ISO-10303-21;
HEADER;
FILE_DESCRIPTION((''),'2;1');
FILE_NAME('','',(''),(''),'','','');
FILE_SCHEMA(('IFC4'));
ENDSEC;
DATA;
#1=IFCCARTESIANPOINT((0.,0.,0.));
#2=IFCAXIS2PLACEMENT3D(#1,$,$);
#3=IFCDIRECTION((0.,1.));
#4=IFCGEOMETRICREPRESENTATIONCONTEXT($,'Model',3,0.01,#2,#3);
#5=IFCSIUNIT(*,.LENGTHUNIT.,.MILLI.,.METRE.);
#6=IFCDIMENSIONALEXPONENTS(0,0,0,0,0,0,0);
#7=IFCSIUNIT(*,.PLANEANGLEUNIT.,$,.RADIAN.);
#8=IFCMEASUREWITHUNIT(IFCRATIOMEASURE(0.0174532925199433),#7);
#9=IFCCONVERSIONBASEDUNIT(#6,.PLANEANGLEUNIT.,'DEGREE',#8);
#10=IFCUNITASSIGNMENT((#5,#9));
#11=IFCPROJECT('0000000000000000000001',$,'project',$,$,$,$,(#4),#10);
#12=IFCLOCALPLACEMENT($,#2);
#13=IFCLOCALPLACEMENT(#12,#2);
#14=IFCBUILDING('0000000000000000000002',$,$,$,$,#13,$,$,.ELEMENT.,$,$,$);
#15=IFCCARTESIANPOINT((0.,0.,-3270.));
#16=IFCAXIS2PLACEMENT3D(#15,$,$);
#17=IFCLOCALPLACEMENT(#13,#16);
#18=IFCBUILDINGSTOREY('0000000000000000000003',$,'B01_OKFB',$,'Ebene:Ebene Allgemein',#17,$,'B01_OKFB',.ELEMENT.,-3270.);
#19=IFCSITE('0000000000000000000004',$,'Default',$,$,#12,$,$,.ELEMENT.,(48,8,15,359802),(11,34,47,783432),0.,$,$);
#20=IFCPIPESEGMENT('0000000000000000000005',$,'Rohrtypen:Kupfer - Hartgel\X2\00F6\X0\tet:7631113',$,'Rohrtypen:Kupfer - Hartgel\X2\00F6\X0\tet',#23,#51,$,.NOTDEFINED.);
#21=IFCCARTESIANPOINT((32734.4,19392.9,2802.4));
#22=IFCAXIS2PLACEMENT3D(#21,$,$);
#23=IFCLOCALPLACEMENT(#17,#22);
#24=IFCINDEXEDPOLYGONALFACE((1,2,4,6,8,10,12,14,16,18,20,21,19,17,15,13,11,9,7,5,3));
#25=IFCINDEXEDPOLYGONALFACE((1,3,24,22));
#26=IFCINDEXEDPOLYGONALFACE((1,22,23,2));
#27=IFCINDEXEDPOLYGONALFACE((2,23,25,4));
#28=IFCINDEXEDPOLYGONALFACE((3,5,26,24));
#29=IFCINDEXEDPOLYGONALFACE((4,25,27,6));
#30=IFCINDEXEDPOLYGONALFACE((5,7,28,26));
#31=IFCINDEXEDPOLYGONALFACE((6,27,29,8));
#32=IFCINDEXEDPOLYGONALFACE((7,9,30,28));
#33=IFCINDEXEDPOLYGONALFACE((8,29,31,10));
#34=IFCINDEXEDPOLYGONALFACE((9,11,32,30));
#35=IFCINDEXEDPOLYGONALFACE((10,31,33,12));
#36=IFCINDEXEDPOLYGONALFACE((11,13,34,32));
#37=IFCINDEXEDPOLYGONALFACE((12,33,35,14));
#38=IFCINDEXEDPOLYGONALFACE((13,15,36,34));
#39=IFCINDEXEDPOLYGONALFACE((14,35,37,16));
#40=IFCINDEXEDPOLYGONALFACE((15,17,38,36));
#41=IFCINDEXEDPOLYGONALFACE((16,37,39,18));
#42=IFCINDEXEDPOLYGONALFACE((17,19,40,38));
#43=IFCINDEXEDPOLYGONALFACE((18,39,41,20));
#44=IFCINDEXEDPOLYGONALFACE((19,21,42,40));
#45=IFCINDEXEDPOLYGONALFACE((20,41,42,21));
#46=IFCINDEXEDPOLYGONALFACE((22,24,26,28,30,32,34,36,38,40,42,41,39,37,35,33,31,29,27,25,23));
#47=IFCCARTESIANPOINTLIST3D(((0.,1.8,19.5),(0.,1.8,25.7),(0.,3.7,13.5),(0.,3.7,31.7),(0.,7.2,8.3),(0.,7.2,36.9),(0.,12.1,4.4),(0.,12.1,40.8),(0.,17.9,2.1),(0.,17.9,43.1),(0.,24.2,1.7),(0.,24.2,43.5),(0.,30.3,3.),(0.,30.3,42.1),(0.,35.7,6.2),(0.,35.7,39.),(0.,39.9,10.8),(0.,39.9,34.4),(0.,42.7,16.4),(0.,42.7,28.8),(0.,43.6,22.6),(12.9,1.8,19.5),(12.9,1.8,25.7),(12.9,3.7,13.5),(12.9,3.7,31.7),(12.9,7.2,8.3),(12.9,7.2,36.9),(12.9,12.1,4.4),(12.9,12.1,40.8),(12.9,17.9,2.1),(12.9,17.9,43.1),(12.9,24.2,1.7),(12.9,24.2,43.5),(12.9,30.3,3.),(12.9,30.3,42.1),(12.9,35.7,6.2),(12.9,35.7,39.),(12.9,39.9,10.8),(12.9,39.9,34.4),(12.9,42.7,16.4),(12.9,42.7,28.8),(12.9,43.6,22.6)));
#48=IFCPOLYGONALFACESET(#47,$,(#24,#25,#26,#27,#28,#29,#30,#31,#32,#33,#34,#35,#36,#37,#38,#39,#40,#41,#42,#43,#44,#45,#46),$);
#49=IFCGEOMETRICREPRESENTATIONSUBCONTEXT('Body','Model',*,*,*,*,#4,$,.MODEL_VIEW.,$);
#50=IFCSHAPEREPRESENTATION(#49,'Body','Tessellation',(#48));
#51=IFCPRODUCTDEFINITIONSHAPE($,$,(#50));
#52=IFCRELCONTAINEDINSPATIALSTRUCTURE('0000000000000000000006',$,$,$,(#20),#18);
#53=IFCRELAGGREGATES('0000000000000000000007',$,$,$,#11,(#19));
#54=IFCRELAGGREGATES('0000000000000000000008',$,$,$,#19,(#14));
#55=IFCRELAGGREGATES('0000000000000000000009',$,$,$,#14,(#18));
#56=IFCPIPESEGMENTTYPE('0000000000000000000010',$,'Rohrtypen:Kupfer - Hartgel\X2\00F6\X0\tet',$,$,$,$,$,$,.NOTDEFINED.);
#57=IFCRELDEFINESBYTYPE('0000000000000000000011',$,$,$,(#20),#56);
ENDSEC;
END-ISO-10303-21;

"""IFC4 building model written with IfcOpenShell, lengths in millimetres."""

from ifc_helpers import new_model, entity, si_unit, converted_unit, direction, frame, origin, origin_2d_with_axis, place, context, subcontext, project, spatial, circle, extrude, type_object, element, save


model = new_model("IFC4")

# Units and contexts
model_context = context("Model", 3, precision=0.01, world=origin(), true_north=direction((0.0, 1.0)))
body_context = subcontext(model_context, "Body", "Model", "MODEL_VIEW")
ifc_project = project(units=[si_unit("LENGTHUNIT", "METRE", prefix="MILLI"), converted_unit("PLANEANGLEUNIT", "DEGREE", entity("IfcRatioMeasure", 0.0174532925199433), si_unit("PLANEANGLEUNIT", "RADIAN"), dimensions=[0, 0, 0, 0, 0, 0, 0])], contexts=[model_context])

# Site, building, storey
site_placement = place(None, origin())
site = spatial("IfcSite", under=ifc_project, at=site_placement, Name="Default", CompositionType="ELEMENT", RefLatitude=(48, 8, 15, 359802), RefLongitude=(11, 34, 47, 783432), RefElevation=0.0)
building_placement = place(site_placement, origin())
building = spatial("IfcBuilding", under=site, at=building_placement, CompositionType="ELEMENT")
storey_placement = place(building_placement, frame((0.0, 0.0, -3270.0)))
storey = spatial("IfcBuildingStorey", under=building, at=storey_placement, Name="B01_OKFB", ObjectType="Ebene:Ebene Allgemein", LongName="B01_OKFB", CompositionType="ELEMENT", Elevation=-3270.0)

# Pipe segment
pipe_segment_type = type_object("IfcPipeSegmentType", Name="Rohrtypen:Kupfer - Hartgelötet", PredefinedType="NOTDEFINED")
pipe_segment_1_placement = place(storey_placement, frame((32734.4, 19392.9, 2802.4)))
element("IfcPipeSegment", 1, at=pipe_segment_1_placement, inside=storey, type_object=pipe_segment_type, Name="Rohrtypen:Kupfer - Hartgelötet:7631113", ObjectType="Rohrtypen:Kupfer - Hartgelötet", PredefinedType="NOTDEFINED", context=body_context, shape_type="SweptSolid", body=[
    extrude(circle(Radius=21.0, at=origin_2d_with_axis()), frame((0.0, 22.6, 22.6), z_axis=(1.0, 0.0, 0.0), x_axis=(0.0, 1.0, 0.0)), (0.0, 0.0, 1.0), 12.9),
])

save(model, "model.ifc")
